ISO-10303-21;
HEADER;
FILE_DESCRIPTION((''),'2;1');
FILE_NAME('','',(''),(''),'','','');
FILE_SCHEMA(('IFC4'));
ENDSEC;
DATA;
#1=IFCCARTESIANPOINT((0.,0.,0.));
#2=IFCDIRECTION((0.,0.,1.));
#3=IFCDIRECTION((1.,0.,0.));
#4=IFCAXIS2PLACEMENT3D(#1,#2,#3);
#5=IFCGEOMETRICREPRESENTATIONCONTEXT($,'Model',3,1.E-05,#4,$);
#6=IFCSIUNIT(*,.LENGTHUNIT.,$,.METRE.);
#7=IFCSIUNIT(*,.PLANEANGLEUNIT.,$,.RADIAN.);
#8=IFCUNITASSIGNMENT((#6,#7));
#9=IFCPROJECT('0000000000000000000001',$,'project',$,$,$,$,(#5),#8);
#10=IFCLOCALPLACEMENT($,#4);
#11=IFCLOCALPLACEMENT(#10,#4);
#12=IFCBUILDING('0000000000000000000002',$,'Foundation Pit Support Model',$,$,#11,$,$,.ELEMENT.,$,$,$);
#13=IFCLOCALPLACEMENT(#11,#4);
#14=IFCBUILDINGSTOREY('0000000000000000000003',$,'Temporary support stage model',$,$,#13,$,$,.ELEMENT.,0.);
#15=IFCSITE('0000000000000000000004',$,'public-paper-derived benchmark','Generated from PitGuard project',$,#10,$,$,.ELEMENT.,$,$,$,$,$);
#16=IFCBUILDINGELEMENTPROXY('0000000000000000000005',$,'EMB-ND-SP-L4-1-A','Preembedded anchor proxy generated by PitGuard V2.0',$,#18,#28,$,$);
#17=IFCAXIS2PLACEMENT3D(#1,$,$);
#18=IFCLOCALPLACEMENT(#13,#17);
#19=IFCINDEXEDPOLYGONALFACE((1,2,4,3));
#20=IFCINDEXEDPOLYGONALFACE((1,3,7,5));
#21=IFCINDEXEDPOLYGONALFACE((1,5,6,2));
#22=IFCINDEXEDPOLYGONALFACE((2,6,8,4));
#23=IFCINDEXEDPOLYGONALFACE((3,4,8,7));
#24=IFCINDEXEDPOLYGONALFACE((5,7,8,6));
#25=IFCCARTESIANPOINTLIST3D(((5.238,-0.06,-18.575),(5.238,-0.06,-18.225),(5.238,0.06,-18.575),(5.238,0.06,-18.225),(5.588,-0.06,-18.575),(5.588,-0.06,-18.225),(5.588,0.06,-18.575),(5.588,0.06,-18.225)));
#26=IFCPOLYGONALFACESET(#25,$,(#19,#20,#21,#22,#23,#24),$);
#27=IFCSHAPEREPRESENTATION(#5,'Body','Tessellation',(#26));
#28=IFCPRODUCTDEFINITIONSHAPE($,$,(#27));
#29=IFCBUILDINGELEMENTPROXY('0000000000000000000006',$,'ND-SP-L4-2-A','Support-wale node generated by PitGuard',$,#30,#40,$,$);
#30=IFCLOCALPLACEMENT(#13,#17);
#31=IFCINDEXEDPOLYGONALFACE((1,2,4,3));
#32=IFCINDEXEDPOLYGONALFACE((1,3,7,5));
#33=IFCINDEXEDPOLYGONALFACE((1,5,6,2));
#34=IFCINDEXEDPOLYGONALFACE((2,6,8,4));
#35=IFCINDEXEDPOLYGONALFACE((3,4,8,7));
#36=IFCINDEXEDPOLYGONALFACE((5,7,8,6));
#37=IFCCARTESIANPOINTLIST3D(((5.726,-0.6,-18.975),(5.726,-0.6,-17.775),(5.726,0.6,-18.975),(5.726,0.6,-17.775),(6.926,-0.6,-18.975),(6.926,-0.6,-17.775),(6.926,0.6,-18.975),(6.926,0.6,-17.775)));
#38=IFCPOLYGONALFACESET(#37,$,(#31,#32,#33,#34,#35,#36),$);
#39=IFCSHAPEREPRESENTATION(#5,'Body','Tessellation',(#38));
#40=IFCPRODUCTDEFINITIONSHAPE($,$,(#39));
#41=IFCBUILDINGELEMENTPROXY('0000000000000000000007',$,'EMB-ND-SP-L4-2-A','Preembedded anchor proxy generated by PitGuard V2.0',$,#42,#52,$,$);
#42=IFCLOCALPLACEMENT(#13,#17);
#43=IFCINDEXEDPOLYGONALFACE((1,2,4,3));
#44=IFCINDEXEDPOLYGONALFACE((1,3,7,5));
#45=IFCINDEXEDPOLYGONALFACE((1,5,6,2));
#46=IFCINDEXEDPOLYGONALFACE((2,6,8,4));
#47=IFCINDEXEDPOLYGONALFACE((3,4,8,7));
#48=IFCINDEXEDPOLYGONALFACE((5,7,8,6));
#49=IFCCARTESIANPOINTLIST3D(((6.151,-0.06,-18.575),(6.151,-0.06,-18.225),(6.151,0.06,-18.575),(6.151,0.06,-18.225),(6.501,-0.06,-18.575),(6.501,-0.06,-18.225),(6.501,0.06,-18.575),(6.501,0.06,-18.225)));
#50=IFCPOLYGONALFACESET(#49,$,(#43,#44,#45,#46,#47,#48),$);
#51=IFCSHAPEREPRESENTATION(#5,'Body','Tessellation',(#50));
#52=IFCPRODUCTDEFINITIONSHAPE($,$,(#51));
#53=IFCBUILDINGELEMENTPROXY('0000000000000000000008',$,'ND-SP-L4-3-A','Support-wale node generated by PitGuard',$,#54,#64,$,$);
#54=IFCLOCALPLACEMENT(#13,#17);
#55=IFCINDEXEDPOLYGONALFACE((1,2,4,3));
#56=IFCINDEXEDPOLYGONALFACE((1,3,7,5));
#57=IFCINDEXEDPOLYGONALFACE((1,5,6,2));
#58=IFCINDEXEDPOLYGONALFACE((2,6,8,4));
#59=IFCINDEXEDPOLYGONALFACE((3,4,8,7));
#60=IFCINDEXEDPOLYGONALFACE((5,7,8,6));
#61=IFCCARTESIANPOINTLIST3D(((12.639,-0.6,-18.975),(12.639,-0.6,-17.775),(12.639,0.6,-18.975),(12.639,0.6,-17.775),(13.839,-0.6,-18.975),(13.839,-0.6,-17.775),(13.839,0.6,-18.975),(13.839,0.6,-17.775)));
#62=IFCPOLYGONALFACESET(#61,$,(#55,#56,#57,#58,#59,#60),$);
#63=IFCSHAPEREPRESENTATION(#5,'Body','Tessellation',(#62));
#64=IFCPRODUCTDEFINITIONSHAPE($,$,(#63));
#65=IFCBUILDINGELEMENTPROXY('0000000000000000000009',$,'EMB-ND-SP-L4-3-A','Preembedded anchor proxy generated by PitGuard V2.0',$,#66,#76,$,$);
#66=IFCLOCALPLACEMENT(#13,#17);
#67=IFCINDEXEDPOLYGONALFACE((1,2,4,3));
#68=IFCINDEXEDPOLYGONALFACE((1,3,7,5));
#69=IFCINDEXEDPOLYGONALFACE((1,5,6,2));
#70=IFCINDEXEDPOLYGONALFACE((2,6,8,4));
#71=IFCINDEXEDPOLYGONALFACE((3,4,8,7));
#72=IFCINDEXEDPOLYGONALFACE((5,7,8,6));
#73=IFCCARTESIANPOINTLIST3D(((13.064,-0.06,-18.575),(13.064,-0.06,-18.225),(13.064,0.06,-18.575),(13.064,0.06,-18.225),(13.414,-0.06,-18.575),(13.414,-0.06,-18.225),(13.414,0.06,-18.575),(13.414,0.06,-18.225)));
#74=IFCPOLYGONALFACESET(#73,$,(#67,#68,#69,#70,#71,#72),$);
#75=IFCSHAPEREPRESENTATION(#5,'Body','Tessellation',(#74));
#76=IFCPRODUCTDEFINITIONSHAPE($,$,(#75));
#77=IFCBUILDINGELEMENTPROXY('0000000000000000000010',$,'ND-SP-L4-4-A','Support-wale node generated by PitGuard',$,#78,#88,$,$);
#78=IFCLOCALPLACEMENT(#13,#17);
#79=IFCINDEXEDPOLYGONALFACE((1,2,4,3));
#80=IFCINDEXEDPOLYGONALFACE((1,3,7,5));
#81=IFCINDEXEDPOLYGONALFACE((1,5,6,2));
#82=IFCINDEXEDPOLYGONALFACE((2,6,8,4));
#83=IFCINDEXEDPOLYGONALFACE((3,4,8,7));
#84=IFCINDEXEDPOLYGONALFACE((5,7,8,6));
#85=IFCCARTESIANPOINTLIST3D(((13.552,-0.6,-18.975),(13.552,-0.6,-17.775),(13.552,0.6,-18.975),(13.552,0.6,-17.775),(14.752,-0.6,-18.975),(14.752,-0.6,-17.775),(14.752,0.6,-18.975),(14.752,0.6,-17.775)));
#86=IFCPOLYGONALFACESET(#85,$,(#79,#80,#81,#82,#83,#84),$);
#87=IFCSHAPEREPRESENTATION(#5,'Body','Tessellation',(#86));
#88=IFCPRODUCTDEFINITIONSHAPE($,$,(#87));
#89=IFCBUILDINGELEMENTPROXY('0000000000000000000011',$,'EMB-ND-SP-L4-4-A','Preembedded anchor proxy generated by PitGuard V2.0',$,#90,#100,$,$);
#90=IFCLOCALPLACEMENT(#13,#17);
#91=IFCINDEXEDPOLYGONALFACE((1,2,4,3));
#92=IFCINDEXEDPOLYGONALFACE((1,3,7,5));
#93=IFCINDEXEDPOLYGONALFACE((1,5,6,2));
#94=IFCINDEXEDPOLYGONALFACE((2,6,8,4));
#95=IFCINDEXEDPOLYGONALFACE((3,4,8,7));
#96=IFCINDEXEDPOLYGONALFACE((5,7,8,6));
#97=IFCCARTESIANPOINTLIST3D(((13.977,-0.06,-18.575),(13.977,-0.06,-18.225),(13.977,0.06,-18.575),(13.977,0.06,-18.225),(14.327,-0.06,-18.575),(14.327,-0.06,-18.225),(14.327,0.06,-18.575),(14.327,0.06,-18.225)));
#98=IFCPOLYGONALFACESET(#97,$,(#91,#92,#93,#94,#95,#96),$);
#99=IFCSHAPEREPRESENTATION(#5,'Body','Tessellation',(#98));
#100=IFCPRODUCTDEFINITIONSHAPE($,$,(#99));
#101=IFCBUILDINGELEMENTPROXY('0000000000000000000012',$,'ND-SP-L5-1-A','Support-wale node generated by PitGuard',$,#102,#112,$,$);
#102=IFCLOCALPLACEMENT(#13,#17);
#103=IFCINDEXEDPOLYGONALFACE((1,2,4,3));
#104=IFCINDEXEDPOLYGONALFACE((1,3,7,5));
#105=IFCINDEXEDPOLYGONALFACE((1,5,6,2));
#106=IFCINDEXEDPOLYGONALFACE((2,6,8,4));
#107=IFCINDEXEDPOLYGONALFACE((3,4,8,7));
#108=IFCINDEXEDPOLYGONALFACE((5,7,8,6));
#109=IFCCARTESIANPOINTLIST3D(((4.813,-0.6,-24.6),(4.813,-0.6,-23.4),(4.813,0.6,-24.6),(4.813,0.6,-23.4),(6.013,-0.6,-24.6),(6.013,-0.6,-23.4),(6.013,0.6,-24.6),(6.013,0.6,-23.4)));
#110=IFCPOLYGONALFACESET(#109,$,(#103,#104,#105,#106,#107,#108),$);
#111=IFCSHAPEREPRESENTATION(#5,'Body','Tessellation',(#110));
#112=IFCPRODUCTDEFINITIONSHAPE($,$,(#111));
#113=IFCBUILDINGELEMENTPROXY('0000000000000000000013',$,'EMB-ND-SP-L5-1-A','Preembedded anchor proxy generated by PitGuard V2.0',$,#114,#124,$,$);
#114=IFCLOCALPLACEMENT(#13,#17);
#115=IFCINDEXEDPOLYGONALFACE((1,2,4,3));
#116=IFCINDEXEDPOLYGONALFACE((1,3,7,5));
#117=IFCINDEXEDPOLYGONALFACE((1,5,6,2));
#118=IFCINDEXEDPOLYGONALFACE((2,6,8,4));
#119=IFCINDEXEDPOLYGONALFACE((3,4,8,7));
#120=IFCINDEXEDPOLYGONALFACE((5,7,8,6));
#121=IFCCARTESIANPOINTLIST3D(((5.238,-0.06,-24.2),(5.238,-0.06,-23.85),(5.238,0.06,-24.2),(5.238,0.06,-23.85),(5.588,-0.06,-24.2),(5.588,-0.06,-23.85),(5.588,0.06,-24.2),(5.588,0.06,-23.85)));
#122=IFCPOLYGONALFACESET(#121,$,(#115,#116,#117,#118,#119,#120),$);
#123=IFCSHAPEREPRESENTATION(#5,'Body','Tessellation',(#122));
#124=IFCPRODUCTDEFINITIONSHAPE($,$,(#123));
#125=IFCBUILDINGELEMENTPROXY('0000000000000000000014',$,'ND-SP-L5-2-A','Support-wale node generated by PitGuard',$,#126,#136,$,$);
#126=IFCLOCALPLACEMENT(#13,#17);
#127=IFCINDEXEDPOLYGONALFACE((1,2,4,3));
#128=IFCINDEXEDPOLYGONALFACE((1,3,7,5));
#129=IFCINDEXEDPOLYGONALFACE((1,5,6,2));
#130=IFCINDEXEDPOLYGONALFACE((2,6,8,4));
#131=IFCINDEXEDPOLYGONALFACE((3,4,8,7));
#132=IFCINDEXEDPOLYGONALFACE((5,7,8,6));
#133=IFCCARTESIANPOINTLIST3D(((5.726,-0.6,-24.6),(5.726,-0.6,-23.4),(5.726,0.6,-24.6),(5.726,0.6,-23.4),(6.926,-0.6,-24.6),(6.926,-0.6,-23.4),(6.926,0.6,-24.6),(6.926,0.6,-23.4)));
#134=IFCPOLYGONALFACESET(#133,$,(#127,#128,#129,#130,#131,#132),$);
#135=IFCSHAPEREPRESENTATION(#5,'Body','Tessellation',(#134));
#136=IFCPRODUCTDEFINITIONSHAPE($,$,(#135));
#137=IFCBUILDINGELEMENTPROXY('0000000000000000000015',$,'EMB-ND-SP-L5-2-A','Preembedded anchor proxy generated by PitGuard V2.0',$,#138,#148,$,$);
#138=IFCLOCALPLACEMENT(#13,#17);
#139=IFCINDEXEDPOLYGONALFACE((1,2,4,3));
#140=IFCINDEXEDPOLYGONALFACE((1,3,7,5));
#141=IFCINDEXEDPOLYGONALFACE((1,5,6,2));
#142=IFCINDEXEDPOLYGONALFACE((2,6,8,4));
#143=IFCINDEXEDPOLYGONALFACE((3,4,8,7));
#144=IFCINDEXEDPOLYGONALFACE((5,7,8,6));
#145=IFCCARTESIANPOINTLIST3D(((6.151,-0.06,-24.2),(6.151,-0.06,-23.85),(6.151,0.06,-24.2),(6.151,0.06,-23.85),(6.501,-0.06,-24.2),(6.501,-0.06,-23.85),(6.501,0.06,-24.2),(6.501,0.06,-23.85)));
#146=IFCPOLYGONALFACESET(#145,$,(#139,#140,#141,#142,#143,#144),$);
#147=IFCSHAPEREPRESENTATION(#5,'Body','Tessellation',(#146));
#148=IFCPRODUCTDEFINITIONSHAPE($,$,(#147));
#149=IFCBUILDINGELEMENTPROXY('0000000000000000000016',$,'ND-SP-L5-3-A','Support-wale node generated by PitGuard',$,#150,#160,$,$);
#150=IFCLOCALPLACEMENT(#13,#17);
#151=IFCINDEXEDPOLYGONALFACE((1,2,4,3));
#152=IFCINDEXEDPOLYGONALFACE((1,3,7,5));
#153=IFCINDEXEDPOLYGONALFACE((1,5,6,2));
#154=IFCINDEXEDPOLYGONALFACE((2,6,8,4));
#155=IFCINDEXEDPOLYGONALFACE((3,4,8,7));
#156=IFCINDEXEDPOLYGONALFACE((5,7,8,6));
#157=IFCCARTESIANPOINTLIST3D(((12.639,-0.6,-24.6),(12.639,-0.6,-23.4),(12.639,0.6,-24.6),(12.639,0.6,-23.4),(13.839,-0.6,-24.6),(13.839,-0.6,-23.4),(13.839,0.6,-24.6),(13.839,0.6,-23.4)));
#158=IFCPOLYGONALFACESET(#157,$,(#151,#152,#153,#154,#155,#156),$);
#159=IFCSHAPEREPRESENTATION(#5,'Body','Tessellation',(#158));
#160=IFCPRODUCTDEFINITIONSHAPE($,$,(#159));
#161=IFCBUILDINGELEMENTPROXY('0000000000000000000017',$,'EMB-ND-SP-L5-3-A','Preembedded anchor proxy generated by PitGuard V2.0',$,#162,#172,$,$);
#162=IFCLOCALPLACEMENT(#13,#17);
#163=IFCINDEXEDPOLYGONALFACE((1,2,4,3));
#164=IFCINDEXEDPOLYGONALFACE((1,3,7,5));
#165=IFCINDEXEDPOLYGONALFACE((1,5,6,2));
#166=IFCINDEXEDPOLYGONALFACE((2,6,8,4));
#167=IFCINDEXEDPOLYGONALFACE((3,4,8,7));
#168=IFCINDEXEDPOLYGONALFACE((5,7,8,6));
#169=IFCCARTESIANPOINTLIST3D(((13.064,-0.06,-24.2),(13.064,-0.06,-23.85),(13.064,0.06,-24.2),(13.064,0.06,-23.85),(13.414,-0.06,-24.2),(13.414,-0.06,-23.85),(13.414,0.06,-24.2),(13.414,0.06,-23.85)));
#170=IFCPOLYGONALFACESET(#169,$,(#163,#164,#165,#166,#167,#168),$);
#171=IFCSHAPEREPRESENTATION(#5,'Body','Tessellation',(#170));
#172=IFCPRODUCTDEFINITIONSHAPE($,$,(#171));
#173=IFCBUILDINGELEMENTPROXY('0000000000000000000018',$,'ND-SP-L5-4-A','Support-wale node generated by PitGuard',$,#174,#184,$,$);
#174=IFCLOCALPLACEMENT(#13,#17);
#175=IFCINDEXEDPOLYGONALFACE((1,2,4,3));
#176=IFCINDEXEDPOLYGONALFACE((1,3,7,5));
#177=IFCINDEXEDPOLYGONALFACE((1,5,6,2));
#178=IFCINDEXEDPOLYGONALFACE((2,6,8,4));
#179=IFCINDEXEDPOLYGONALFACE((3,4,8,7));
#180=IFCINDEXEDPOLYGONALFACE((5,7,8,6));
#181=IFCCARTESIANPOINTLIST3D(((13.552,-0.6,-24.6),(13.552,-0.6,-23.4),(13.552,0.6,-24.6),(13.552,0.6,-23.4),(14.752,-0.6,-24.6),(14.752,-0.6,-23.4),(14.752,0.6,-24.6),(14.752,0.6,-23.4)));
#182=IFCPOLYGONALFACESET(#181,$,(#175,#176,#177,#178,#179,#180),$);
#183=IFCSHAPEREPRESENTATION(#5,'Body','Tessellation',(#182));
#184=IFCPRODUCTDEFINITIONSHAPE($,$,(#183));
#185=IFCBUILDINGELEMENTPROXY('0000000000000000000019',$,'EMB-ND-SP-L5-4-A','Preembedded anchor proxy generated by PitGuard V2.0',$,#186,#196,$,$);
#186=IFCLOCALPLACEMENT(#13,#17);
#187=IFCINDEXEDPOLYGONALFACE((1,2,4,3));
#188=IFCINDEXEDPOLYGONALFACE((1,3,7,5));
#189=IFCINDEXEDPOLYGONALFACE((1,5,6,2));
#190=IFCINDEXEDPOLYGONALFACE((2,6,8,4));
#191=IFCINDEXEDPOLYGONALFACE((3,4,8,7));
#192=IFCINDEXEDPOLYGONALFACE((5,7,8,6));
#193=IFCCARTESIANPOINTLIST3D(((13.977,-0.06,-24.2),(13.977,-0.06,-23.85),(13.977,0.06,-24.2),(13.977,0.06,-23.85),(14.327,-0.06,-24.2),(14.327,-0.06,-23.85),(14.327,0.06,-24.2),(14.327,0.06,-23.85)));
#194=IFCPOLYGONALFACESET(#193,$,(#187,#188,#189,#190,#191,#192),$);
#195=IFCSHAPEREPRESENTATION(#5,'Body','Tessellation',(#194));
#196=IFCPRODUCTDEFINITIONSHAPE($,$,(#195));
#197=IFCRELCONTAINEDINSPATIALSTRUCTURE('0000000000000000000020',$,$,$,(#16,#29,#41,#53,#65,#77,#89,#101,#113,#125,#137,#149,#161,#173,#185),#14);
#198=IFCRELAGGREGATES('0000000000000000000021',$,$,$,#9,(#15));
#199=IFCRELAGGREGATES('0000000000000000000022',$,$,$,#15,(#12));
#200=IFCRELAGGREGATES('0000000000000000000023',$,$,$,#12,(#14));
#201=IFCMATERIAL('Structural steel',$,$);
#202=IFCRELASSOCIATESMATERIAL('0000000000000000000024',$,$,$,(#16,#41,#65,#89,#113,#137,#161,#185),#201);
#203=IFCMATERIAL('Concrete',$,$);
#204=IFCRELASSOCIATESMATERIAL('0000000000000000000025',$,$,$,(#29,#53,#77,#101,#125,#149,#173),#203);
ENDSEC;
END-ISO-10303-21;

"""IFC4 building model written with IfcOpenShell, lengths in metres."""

from ifc_helpers import new_model, si_unit, frame, origin_with_axes, origin_2d, place, context, project, spatial, rectangle, extrude, material, element, save


model = new_model("IFC4")

# Units and contexts
model_context = context("Model", 3, precision=1e-05, world=origin_with_axes())
ifc_project = project(units=[si_unit("LENGTHUNIT", "METRE"), si_unit("PLANEANGLEUNIT", "RADIAN")], contexts=[model_context])

# Site, building, storey
site_placement = place(None, origin_with_axes())
site = spatial("IfcSite", under=ifc_project, at=site_placement, Name="public-paper-derived benchmark", Description="Generated from PitGuard project", CompositionType="ELEMENT")
building_placement = place(site_placement, origin_with_axes())
building = spatial("IfcBuilding", under=site, at=building_placement, Name="Foundation Pit Support Model", CompositionType="ELEMENT")
storey_placement = place(building_placement, origin_with_axes())
storey = spatial("IfcBuildingStorey", under=building, at=storey_placement, Name="Temporary support stage model", CompositionType="ELEMENT", Elevation=0.0)

# Shared definitions
ifc_material_1 = material(Name="Structural steel")

# Shared definitions
ifc_material_2 = material(Name="Concrete")

# Building element proxies
proxy_1_placement = place(storey_placement, frame((5.413, 0.0, -18.575), z_axis=(0.0, 0.0, 1.0), x_axis=(1.0, 0.0, 0.0)))
element("IfcBuildingElementProxy", 1, at=proxy_1_placement, inside=storey, material=ifc_material_1, Name="EMB-ND-SP-L4-1-A", Description="Preembedded anchor proxy generated by PitGuard V2.0", context=model_context, shape_type="SweptSolid", body=[
    extrude(rectangle(XDim=0.35, YDim=0.12, at=origin_2d()), origin_with_axes(), (0.0, 0.0, 1.0), 0.35),
])
proxy_2_placement = place(storey_placement, frame((6.326, 0.0, -18.975), z_axis=(0.0, 0.0, 1.0), x_axis=(1.0, 0.0, 0.0)))
element("IfcBuildingElementProxy", 2, at=proxy_2_placement, inside=storey, material=ifc_material_2, Name="ND-SP-L4-2-A", Description="Support-wale node generated by PitGuard", context=model_context, shape_type="SweptSolid", body=[
    extrude(rectangle(XDim=1.2, YDim=1.2, at=origin_2d()), origin_with_axes(), (0.0, 0.0, 1.0), 1.2),
])
proxy_3_placement = place(storey_placement, frame((6.326, 0.0, -18.575), z_axis=(0.0, 0.0, 1.0), x_axis=(1.0, 0.0, 0.0)))
element("IfcBuildingElementProxy", 3, at=proxy_3_placement, inside=storey, material=ifc_material_1, Name="EMB-ND-SP-L4-2-A", Description="Preembedded anchor proxy generated by PitGuard V2.0", context=model_context, shape_type="SweptSolid", body=[
    extrude(rectangle(XDim=0.35, YDim=0.12, at=origin_2d()), origin_with_axes(), (0.0, 0.0, 1.0), 0.35),
])
proxy_4_placement = place(storey_placement, frame((13.239, 0.0, -18.975), z_axis=(0.0, 0.0, 1.0), x_axis=(1.0, 0.0, 0.0)))
element("IfcBuildingElementProxy", 4, at=proxy_4_placement, inside=storey, material=ifc_material_2, Name="ND-SP-L4-3-A", Description="Support-wale node generated by PitGuard", context=model_context, shape_type="SweptSolid", body=[
    extrude(rectangle(XDim=1.2, YDim=1.2, at=origin_2d()), origin_with_axes(), (0.0, 0.0, 1.0), 1.2),
])
proxy_5_placement = place(storey_placement, frame((13.239, 0.0, -18.575), z_axis=(0.0, 0.0, 1.0), x_axis=(1.0, 0.0, 0.0)))
element("IfcBuildingElementProxy", 5, at=proxy_5_placement, inside=storey, material=ifc_material_1, Name="EMB-ND-SP-L4-3-A", Description="Preembedded anchor proxy generated by PitGuard V2.0", context=model_context, shape_type="SweptSolid", body=[
    extrude(rectangle(XDim=0.35, YDim=0.12, at=origin_2d()), origin_with_axes(), (0.0, 0.0, 1.0), 0.35),
])
proxy_6_placement = place(storey_placement, frame((14.152, 0.0, -18.975), z_axis=(0.0, 0.0, 1.0), x_axis=(1.0, 0.0, 0.0)))
element("IfcBuildingElementProxy", 6, at=proxy_6_placement, inside=storey, material=ifc_material_2, Name="ND-SP-L4-4-A", Description="Support-wale node generated by PitGuard", context=model_context, shape_type="SweptSolid", body=[
    extrude(rectangle(XDim=1.2, YDim=1.2, at=origin_2d()), origin_with_axes(), (0.0, 0.0, 1.0), 1.2),
])
proxy_7_placement = place(storey_placement, frame((14.152, 0.0, -18.575), z_axis=(0.0, 0.0, 1.0), x_axis=(1.0, 0.0, 0.0)))
element("IfcBuildingElementProxy", 7, at=proxy_7_placement, inside=storey, material=ifc_material_1, Name="EMB-ND-SP-L4-4-A", Description="Preembedded anchor proxy generated by PitGuard V2.0", context=model_context, shape_type="SweptSolid", body=[
    extrude(rectangle(XDim=0.35, YDim=0.12, at=origin_2d()), origin_with_axes(), (0.0, 0.0, 1.0), 0.35),
])
proxy_8_placement = place(storey_placement, frame((5.413, 0.0, -24.6), z_axis=(0.0, 0.0, 1.0), x_axis=(1.0, 0.0, 0.0)))
element("IfcBuildingElementProxy", 8, at=proxy_8_placement, inside=storey, material=ifc_material_2, Name="ND-SP-L5-1-A", Description="Support-wale node generated by PitGuard", context=model_context, shape_type="SweptSolid", body=[
    extrude(rectangle(XDim=1.2, YDim=1.2, at=origin_2d()), origin_with_axes(), (0.0, 0.0, 1.0), 1.2),
])
proxy_9_placement = place(storey_placement, frame((5.413, 0.0, -24.2), z_axis=(0.0, 0.0, 1.0), x_axis=(1.0, 0.0, 0.0)))
element("IfcBuildingElementProxy", 9, at=proxy_9_placement, inside=storey, material=ifc_material_1, Name="EMB-ND-SP-L5-1-A", Description="Preembedded anchor proxy generated by PitGuard V2.0", context=model_context, shape_type="SweptSolid", body=[
    extrude(rectangle(XDim=0.35, YDim=0.12, at=origin_2d()), origin_with_axes(), (0.0, 0.0, 1.0), 0.35),
])
proxy_10_placement = place(storey_placement, frame((6.326, 0.0, -24.6), z_axis=(0.0, 0.0, 1.0), x_axis=(1.0, 0.0, 0.0)))
element("IfcBuildingElementProxy", 10, at=proxy_10_placement, inside=storey, material=ifc_material_2, Name="ND-SP-L5-2-A", Description="Support-wale node generated by PitGuard", context=model_context, shape_type="SweptSolid", body=[
    extrude(rectangle(XDim=1.2, YDim=1.2, at=origin_2d()), origin_with_axes(), (0.0, 0.0, 1.0), 1.2),
])
proxy_11_placement = place(storey_placement, frame((6.326, 0.0, -24.2), z_axis=(0.0, 0.0, 1.0), x_axis=(1.0, 0.0, 0.0)))
element("IfcBuildingElementProxy", 11, at=proxy_11_placement, inside=storey, material=ifc_material_1, Name="EMB-ND-SP-L5-2-A", Description="Preembedded anchor proxy generated by PitGuard V2.0", context=model_context, shape_type="SweptSolid", body=[
    extrude(rectangle(XDim=0.35, YDim=0.12, at=origin_2d()), origin_with_axes(), (0.0, 0.0, 1.0), 0.35),
])
proxy_12_placement = place(storey_placement, frame((13.239, 0.0, -24.6), z_axis=(0.0, 0.0, 1.0), x_axis=(1.0, 0.0, 0.0)))
element("IfcBuildingElementProxy", 12, at=proxy_12_placement, inside=storey, material=ifc_material_2, Name="ND-SP-L5-3-A", Description="Support-wale node generated by PitGuard", context=model_context, shape_type="SweptSolid", body=[
    extrude(rectangle(XDim=1.2, YDim=1.2, at=origin_2d()), origin_with_axes(), (0.0, 0.0, 1.0), 1.2),
])
proxy_13_placement = place(storey_placement, frame((13.239, 0.0, -24.2), z_axis=(0.0, 0.0, 1.0), x_axis=(1.0, 0.0, 0.0)))
element("IfcBuildingElementProxy", 13, at=proxy_13_placement, inside=storey, material=ifc_material_1, Name="EMB-ND-SP-L5-3-A", Description="Preembedded anchor proxy generated by PitGuard V2.0", context=model_context, shape_type="SweptSolid", body=[
    extrude(rectangle(XDim=0.35, YDim=0.12, at=origin_2d()), origin_with_axes(), (0.0, 0.0, 1.0), 0.35),
])
proxy_14_placement = place(storey_placement, frame((14.152, 0.0, -24.6), z_axis=(0.0, 0.0, 1.0), x_axis=(1.0, 0.0, 0.0)))
element("IfcBuildingElementProxy", 14, at=proxy_14_placement, inside=storey, material=ifc_material_2, Name="ND-SP-L5-4-A", Description="Support-wale node generated by PitGuard", context=model_context, shape_type="SweptSolid", body=[
    extrude(rectangle(XDim=1.2, YDim=1.2, at=origin_2d()), origin_with_axes(), (0.0, 0.0, 1.0), 1.2),
])
proxy_15_placement = place(storey_placement, frame((14.152, 0.0, -24.2), z_axis=(0.0, 0.0, 1.0), x_axis=(1.0, 0.0, 0.0)))
element("IfcBuildingElementProxy", 15, at=proxy_15_placement, inside=storey, material=ifc_material_1, Name="EMB-ND-SP-L5-4-A", Description="Preembedded anchor proxy generated by PitGuard V2.0", context=model_context, shape_type="SweptSolid", body=[
    extrude(rectangle(XDim=0.35, YDim=0.12, at=origin_2d()), origin_with_axes(), (0.0, 0.0, 1.0), 0.35),
])

save(model, "model.ifc")
